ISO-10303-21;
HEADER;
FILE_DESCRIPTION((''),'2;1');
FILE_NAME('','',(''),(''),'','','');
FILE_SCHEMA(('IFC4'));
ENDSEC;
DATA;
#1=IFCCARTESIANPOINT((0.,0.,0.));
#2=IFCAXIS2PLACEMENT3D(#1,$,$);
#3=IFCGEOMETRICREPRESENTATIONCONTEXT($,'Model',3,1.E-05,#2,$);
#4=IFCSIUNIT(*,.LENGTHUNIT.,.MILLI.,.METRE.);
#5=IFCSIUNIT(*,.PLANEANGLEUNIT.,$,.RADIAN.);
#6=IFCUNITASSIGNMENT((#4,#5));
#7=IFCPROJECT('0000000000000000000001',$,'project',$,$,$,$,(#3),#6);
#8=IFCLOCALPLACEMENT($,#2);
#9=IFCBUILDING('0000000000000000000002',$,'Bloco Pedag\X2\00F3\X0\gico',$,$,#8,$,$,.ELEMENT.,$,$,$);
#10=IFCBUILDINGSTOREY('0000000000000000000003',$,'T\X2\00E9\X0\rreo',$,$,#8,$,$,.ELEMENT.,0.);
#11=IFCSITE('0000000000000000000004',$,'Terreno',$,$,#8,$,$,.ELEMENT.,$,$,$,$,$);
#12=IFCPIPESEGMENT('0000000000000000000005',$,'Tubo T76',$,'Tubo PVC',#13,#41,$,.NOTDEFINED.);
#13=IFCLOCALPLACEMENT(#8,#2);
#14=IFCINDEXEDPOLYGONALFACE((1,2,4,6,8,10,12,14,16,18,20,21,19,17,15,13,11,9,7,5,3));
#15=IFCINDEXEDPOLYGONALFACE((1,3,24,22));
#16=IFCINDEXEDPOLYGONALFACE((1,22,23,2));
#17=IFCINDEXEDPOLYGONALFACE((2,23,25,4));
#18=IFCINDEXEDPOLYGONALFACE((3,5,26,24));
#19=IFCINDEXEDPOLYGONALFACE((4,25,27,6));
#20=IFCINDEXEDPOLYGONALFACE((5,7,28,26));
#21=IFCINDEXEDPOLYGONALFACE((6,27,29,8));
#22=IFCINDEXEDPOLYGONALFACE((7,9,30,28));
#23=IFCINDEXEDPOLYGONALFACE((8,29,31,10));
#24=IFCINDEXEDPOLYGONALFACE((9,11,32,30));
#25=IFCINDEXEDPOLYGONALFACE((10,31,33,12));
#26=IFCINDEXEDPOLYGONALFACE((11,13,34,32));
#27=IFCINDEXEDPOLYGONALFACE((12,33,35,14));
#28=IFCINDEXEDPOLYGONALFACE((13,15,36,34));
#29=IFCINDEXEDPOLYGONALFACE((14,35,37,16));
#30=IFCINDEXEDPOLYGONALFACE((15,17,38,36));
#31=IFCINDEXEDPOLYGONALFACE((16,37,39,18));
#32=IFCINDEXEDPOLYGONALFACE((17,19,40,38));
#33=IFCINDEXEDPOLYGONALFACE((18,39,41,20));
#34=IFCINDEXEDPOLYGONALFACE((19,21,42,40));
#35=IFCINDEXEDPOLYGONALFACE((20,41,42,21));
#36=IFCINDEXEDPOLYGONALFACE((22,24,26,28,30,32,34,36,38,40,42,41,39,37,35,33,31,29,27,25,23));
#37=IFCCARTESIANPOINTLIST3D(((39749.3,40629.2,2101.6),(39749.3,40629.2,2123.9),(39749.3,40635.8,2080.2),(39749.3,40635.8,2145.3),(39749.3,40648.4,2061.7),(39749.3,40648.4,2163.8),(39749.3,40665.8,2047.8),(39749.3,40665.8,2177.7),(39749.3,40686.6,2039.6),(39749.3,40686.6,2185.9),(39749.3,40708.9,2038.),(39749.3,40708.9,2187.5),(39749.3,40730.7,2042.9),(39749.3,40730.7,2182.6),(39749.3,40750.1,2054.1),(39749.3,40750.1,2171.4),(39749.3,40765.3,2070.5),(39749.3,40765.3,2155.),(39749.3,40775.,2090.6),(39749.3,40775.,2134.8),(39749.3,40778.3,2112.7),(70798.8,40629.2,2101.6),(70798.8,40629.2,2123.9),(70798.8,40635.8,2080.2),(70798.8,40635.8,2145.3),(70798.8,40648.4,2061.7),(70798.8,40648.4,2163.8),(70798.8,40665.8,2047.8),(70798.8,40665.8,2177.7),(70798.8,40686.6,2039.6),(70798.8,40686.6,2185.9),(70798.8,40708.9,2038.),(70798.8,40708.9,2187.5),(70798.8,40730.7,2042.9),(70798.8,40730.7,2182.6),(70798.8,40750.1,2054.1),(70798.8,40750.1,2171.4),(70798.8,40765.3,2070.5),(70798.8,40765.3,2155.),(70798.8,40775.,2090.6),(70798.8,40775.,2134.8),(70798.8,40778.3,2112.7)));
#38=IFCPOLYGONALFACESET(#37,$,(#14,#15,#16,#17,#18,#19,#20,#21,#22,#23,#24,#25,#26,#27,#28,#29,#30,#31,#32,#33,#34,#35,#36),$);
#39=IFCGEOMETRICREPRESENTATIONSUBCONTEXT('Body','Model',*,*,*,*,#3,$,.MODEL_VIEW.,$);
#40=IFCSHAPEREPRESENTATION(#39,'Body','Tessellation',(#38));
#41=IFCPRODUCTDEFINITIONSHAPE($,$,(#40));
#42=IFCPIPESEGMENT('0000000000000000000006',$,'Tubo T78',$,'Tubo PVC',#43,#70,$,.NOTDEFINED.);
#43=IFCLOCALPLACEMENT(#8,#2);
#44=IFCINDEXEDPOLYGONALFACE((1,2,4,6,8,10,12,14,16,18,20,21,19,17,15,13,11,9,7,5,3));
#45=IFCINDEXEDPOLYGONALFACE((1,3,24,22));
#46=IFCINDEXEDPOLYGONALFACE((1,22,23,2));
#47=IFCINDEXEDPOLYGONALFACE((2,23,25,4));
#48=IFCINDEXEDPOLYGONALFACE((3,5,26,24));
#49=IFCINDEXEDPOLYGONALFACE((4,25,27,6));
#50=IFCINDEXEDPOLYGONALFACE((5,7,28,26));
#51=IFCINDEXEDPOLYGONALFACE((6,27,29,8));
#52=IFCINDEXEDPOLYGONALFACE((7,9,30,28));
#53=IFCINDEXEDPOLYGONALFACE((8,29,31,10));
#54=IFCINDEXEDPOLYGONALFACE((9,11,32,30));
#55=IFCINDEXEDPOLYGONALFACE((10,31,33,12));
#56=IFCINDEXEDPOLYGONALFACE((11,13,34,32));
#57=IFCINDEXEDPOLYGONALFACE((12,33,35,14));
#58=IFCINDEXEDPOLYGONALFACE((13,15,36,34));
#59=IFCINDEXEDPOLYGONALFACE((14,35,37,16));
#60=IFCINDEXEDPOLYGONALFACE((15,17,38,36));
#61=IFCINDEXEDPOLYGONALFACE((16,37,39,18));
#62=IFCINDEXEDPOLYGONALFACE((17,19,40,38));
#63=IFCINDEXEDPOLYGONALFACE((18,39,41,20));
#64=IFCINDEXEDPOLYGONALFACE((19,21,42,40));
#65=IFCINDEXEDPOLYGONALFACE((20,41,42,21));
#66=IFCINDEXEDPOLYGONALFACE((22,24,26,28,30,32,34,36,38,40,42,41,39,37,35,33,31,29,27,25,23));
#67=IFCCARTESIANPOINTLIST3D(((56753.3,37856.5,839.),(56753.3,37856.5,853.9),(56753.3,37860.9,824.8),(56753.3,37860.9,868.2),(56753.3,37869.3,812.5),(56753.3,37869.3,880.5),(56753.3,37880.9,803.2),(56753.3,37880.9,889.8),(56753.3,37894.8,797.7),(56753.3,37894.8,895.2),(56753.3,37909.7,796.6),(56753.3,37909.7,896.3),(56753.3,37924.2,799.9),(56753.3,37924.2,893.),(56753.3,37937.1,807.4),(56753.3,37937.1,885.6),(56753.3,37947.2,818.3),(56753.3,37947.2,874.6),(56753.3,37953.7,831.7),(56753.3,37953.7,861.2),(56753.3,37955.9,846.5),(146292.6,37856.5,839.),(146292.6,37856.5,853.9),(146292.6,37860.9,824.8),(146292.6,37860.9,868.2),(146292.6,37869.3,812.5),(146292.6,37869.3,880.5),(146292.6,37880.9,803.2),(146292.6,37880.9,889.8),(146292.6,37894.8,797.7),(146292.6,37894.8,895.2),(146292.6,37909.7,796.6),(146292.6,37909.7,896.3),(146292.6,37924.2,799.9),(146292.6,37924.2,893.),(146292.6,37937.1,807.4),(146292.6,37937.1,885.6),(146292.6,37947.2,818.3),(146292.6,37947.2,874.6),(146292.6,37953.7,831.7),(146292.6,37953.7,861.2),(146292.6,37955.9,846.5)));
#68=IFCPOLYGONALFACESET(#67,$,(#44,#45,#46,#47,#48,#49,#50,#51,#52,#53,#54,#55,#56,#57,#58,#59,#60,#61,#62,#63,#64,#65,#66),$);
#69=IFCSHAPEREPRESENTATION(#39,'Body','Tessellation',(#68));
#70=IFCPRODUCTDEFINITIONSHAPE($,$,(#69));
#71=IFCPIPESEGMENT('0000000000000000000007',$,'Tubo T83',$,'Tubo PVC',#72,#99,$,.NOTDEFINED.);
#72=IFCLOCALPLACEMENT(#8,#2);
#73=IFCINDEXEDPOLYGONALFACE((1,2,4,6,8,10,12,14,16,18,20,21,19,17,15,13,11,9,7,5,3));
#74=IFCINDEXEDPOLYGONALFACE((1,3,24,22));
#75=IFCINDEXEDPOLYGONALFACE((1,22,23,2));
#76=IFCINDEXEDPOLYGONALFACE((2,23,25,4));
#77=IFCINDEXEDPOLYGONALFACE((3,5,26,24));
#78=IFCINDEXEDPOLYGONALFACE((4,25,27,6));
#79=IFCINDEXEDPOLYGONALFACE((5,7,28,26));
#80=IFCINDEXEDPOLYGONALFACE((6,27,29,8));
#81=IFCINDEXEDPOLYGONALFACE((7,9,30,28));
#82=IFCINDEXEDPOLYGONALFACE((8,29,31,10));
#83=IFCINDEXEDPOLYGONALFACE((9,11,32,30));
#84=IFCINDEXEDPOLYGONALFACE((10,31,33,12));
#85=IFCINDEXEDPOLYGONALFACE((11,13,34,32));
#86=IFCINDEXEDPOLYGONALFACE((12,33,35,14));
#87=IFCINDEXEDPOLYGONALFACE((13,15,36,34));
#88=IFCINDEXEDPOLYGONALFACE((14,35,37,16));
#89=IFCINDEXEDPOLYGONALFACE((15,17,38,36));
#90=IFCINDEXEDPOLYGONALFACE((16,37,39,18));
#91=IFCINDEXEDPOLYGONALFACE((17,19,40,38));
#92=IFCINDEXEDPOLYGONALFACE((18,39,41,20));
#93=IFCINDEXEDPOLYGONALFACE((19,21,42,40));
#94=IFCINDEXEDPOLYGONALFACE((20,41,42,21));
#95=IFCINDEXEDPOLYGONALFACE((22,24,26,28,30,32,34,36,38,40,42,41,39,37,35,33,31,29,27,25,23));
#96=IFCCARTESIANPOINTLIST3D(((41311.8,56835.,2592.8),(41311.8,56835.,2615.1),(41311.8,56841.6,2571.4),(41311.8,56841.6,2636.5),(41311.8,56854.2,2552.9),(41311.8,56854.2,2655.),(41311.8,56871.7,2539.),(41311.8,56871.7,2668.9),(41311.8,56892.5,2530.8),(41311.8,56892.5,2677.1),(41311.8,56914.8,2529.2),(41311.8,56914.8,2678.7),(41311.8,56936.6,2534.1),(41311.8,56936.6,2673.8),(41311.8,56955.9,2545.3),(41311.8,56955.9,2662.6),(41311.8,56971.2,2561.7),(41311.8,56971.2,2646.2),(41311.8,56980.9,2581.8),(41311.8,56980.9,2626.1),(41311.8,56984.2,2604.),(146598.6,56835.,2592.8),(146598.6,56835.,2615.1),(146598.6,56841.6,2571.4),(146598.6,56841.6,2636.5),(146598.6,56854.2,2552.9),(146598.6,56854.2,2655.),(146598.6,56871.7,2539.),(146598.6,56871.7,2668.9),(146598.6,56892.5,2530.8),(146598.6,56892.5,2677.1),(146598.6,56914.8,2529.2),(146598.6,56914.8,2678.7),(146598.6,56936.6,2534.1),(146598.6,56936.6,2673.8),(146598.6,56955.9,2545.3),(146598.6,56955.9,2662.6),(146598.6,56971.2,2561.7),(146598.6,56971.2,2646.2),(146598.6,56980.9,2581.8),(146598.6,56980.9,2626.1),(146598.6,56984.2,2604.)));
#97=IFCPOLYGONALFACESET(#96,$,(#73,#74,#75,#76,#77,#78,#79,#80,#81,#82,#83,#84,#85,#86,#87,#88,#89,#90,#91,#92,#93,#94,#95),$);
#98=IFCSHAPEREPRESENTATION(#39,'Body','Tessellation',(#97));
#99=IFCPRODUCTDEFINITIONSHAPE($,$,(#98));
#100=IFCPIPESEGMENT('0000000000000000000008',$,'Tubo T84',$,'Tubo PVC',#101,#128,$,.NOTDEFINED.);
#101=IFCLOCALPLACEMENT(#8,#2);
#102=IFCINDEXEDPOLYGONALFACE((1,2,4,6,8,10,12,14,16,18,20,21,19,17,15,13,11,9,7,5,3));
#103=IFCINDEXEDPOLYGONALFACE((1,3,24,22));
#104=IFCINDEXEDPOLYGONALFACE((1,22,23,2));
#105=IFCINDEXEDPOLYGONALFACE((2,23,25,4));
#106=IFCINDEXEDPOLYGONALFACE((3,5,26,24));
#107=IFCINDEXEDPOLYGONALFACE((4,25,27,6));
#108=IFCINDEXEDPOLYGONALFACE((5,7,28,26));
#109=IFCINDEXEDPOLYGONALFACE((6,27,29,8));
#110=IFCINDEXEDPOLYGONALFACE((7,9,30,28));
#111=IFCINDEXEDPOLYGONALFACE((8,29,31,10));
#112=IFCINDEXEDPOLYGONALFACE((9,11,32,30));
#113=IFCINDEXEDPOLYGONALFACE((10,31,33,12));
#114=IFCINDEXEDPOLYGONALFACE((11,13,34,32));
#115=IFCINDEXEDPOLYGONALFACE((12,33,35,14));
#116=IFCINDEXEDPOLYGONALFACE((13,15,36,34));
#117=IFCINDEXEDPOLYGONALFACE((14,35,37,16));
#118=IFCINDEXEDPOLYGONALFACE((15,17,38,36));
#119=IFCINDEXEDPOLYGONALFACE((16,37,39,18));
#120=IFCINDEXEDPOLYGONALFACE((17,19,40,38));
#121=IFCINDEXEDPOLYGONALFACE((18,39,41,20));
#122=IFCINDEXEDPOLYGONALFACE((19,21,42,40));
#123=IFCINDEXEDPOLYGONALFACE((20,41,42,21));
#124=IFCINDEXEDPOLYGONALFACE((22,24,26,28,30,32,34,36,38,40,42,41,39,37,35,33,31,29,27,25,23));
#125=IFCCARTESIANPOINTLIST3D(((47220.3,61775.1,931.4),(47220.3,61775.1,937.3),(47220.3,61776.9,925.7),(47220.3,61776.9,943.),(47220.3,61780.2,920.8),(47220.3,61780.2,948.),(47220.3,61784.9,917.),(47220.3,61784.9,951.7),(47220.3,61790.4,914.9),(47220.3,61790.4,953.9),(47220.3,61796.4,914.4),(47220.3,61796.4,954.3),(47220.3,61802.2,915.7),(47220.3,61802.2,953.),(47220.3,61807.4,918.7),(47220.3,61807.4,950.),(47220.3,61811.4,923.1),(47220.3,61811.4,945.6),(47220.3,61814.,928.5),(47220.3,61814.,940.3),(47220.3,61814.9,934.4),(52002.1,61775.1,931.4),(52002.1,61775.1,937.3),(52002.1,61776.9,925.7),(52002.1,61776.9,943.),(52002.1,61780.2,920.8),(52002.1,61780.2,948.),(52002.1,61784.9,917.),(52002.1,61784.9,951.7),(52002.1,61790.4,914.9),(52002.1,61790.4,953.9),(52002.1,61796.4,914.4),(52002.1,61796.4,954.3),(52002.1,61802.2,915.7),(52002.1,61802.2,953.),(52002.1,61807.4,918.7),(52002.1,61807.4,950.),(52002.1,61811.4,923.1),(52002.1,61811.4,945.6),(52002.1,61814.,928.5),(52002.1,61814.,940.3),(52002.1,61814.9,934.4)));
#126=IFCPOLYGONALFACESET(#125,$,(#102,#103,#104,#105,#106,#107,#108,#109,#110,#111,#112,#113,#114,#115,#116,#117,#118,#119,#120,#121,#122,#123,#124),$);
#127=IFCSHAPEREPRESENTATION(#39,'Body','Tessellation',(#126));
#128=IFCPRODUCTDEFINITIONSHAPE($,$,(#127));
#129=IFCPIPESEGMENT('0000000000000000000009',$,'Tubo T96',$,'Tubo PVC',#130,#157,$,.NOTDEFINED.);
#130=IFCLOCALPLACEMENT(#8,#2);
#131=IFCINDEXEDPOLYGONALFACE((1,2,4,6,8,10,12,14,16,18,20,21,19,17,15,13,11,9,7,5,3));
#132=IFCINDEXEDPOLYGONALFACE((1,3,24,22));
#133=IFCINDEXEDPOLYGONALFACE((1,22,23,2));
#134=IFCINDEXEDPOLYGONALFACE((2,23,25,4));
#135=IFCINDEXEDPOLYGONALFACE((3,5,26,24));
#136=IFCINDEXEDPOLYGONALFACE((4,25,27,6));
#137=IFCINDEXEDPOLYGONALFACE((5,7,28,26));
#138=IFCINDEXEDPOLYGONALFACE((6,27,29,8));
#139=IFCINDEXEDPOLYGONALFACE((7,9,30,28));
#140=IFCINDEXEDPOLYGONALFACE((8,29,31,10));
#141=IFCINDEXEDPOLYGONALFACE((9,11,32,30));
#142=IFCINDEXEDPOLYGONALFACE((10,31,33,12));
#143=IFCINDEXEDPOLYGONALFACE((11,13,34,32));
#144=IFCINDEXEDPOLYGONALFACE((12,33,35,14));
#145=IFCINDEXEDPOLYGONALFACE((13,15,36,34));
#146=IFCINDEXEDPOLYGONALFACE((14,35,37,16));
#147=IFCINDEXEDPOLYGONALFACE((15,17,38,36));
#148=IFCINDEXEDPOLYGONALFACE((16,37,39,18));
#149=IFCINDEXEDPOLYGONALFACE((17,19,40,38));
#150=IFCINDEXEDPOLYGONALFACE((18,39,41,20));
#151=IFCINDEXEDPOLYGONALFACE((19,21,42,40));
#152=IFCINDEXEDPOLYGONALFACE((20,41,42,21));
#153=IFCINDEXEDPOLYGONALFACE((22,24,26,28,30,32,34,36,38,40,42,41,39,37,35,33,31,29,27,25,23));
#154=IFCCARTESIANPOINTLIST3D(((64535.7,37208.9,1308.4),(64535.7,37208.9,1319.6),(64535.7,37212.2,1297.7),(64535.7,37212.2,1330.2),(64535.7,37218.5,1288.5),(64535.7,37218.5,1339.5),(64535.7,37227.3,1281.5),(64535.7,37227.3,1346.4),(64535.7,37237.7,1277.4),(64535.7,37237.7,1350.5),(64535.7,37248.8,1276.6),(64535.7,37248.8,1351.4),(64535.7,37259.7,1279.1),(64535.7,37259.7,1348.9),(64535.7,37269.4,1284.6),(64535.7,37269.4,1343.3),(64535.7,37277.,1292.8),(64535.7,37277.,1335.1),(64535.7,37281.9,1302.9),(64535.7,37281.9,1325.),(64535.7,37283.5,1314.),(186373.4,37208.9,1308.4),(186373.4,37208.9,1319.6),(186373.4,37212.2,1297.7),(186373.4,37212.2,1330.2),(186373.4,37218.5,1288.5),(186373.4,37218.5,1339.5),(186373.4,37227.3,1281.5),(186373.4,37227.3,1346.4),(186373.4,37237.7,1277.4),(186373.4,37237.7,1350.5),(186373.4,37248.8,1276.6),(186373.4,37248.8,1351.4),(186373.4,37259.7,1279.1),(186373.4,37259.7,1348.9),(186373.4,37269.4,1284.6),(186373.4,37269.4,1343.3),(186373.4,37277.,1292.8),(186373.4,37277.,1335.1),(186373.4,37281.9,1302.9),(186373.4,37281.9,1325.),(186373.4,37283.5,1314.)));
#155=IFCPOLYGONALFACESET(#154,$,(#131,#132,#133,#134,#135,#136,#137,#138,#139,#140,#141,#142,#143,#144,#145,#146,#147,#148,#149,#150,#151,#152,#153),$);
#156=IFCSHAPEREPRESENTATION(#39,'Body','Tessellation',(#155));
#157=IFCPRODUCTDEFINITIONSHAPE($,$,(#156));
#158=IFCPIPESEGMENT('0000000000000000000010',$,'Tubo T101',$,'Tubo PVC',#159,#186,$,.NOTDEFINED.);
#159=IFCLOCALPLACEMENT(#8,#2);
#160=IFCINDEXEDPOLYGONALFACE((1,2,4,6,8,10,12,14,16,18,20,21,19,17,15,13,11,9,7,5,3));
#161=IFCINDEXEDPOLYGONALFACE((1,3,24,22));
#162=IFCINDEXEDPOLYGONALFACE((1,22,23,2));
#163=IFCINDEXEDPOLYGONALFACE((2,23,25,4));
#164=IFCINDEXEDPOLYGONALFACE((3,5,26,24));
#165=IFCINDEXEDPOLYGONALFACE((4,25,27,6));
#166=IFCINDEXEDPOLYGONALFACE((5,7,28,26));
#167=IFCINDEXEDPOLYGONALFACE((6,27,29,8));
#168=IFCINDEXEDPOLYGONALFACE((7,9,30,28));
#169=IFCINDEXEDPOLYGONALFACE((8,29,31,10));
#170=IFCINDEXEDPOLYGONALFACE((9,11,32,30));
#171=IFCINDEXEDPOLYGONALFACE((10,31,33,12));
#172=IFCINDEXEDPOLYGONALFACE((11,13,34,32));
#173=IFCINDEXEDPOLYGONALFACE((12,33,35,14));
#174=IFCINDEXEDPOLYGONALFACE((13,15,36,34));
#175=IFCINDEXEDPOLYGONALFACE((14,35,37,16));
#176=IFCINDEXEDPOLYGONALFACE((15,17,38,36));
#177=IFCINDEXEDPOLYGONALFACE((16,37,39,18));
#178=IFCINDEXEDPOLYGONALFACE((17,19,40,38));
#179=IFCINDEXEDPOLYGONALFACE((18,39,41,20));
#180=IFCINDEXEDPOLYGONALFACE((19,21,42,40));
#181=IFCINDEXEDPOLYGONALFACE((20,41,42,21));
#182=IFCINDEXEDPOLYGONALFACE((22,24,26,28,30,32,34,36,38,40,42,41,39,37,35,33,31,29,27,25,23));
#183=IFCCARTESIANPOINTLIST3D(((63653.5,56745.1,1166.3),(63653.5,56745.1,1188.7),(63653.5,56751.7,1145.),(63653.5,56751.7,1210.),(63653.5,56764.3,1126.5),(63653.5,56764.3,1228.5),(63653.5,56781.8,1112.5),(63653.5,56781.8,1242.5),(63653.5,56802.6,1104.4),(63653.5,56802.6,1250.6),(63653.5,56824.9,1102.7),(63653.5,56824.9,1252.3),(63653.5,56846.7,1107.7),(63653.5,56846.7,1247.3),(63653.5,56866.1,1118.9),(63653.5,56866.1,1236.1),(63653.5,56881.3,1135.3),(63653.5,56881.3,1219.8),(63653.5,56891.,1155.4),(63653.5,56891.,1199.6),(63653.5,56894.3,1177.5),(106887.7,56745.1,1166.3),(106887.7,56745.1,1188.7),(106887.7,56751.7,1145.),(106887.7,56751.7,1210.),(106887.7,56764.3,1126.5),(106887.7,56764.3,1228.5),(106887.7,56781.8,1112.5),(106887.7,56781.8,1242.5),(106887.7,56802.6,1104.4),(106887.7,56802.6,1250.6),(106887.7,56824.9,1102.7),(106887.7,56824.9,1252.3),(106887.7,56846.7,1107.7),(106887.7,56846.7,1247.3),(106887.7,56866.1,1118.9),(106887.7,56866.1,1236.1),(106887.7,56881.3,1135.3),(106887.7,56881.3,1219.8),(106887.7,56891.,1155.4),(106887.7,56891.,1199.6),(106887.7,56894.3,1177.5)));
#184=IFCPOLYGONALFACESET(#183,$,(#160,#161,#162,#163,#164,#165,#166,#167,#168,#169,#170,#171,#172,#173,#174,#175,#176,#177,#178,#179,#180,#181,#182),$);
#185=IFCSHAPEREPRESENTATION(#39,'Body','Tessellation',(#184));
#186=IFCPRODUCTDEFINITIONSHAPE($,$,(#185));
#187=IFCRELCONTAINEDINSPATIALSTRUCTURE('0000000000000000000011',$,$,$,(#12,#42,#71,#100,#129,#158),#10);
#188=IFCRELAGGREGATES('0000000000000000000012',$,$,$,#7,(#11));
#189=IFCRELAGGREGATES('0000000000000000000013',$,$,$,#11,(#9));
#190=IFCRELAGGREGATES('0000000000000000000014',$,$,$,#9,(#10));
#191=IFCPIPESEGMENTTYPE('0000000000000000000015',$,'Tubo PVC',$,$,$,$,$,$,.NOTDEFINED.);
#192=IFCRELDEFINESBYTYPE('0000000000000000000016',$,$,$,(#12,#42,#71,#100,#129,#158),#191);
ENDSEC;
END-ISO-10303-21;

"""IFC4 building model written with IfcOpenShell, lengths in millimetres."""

from ifc_helpers import new_model, si_unit, frame, origin, origin_2d, place, context, subcontext, project, spatial, circle, extrude, type_object, element, save


model = new_model("IFC4")

# Units and contexts
model_context = context("Model", 3, precision=1e-05, world=origin())
body_context = subcontext(model_context, "Body", "Model", "MODEL_VIEW")
ifc_project = project(units=[si_unit("LENGTHUNIT", "METRE", prefix="MILLI"), si_unit("PLANEANGLEUNIT", "RADIAN")], contexts=[model_context])

# Site, building, storey
placement = place(None, origin())
site = spatial("IfcSite", under=ifc_project, at=placement, Name="Terreno", CompositionType="ELEMENT")
building = spatial("IfcBuilding", under=site, at=placement, Name="Bloco Pedagógico", CompositionType="ELEMENT")
storey = spatial("IfcBuildingStorey", under=building, at=placement, Name="Térreo", CompositionType="ELEMENT", Elevation=0.0)

# Pipe segments
pipe_segment_type = type_object("IfcPipeSegmentType", Name="Tubo PVC", PredefinedType="NOTDEFINED")
pipe_segment_1_placement = place(None, frame((39749.3, 40703.3, 2112.7), z_axis=(1.0, 0.0, 0.0), x_axis=(0.0, 1.0, 0.0)))
element("IfcPipeSegment", 1, at=pipe_segment_1_placement, inside=storey, type_object=pipe_segment_type, Name="Tubo T76", ObjectType="Tubo PVC", PredefinedType="NOTDEFINED", context=body_context, shape_type="SweptSolid", body=[
    extrude(circle(Radius=75.0, at=origin_2d()), None, (0.0, 0.0, 1.0), 31049.5),
])
pipe_segment_2_placement = place(None, frame((56753.3, 37905.9, 846.5), z_axis=(1.0, 0.0, 0.0), x_axis=(0.0, 1.0, 0.0)))
element("IfcPipeSegment", 2, at=pipe_segment_2_placement, inside=storey, type_object=pipe_segment_type, Name="Tubo T78", ObjectType="Tubo PVC", PredefinedType="NOTDEFINED", context=body_context, shape_type="SweptSolid", body=[
    extrude(circle(Radius=50.0, at=origin_2d()), None, (0.0, 0.0, 1.0), 89539.3),
])
pipe_segment_3_placement = place(None, frame((41311.8, 56909.2, 2604.0), z_axis=(1.0, 0.0, 0.0), x_axis=(0.0, 1.0, 0.0)))
element("IfcPipeSegment", 3, at=pipe_segment_3_placement, inside=storey, type_object=pipe_segment_type, Name="Tubo T83", ObjectType="Tubo PVC", PredefinedType="NOTDEFINED", context=body_context, shape_type="SweptSolid", body=[
    extrude(circle(Radius=75.0, at=origin_2d()), None, (0.0, 0.0, 1.0), 105286.8),
])
pipe_segment_4_placement = place(None, frame((47220.3, 61794.9, 934.4), z_axis=(1.0, 0.0, 0.0), x_axis=(0.0, 1.0, 0.0)))
element("IfcPipeSegment", 4, at=pipe_segment_4_placement, inside=storey, type_object=pipe_segment_type, Name="Tubo T84", ObjectType="Tubo PVC", PredefinedType="NOTDEFINED", context=body_context, shape_type="SweptSolid", body=[
    extrude(circle(Radius=20.0, at=origin_2d()), None, (0.0, 0.0, 1.0), 4781.8),
])
pipe_segment_5_placement = place(None, frame((64535.7, 37246.0, 1314.0), z_axis=(1.0, 0.0, 0.0), x_axis=(0.0, 1.0, 0.0)))
element("IfcPipeSegment", 5, at=pipe_segment_5_placement, inside=storey, type_object=pipe_segment_type, Name="Tubo T96", ObjectType="Tubo PVC", PredefinedType="NOTDEFINED", context=body_context, shape_type="SweptSolid", body=[
    extrude(circle(Radius=37.5, at=origin_2d()), None, (0.0, 0.0, 1.0), 121837.7),
])
pipe_segment_6_placement = place(None, frame((63653.5, 56819.3, 1177.5), z_axis=(1.0, 0.0, 0.0), x_axis=(0.0, 1.0, 0.0)))
element("IfcPipeSegment", 6, at=pipe_segment_6_placement, inside=storey, type_object=pipe_segment_type, Name="Tubo T101", ObjectType="Tubo PVC", PredefinedType="NOTDEFINED", context=body_context, shape_type="SweptSolid", body=[
    extrude(circle(Radius=75.0, at=origin_2d()), None, (0.0, 0.0, 1.0), 43234.2),
])

save(model, "model.ifc")
